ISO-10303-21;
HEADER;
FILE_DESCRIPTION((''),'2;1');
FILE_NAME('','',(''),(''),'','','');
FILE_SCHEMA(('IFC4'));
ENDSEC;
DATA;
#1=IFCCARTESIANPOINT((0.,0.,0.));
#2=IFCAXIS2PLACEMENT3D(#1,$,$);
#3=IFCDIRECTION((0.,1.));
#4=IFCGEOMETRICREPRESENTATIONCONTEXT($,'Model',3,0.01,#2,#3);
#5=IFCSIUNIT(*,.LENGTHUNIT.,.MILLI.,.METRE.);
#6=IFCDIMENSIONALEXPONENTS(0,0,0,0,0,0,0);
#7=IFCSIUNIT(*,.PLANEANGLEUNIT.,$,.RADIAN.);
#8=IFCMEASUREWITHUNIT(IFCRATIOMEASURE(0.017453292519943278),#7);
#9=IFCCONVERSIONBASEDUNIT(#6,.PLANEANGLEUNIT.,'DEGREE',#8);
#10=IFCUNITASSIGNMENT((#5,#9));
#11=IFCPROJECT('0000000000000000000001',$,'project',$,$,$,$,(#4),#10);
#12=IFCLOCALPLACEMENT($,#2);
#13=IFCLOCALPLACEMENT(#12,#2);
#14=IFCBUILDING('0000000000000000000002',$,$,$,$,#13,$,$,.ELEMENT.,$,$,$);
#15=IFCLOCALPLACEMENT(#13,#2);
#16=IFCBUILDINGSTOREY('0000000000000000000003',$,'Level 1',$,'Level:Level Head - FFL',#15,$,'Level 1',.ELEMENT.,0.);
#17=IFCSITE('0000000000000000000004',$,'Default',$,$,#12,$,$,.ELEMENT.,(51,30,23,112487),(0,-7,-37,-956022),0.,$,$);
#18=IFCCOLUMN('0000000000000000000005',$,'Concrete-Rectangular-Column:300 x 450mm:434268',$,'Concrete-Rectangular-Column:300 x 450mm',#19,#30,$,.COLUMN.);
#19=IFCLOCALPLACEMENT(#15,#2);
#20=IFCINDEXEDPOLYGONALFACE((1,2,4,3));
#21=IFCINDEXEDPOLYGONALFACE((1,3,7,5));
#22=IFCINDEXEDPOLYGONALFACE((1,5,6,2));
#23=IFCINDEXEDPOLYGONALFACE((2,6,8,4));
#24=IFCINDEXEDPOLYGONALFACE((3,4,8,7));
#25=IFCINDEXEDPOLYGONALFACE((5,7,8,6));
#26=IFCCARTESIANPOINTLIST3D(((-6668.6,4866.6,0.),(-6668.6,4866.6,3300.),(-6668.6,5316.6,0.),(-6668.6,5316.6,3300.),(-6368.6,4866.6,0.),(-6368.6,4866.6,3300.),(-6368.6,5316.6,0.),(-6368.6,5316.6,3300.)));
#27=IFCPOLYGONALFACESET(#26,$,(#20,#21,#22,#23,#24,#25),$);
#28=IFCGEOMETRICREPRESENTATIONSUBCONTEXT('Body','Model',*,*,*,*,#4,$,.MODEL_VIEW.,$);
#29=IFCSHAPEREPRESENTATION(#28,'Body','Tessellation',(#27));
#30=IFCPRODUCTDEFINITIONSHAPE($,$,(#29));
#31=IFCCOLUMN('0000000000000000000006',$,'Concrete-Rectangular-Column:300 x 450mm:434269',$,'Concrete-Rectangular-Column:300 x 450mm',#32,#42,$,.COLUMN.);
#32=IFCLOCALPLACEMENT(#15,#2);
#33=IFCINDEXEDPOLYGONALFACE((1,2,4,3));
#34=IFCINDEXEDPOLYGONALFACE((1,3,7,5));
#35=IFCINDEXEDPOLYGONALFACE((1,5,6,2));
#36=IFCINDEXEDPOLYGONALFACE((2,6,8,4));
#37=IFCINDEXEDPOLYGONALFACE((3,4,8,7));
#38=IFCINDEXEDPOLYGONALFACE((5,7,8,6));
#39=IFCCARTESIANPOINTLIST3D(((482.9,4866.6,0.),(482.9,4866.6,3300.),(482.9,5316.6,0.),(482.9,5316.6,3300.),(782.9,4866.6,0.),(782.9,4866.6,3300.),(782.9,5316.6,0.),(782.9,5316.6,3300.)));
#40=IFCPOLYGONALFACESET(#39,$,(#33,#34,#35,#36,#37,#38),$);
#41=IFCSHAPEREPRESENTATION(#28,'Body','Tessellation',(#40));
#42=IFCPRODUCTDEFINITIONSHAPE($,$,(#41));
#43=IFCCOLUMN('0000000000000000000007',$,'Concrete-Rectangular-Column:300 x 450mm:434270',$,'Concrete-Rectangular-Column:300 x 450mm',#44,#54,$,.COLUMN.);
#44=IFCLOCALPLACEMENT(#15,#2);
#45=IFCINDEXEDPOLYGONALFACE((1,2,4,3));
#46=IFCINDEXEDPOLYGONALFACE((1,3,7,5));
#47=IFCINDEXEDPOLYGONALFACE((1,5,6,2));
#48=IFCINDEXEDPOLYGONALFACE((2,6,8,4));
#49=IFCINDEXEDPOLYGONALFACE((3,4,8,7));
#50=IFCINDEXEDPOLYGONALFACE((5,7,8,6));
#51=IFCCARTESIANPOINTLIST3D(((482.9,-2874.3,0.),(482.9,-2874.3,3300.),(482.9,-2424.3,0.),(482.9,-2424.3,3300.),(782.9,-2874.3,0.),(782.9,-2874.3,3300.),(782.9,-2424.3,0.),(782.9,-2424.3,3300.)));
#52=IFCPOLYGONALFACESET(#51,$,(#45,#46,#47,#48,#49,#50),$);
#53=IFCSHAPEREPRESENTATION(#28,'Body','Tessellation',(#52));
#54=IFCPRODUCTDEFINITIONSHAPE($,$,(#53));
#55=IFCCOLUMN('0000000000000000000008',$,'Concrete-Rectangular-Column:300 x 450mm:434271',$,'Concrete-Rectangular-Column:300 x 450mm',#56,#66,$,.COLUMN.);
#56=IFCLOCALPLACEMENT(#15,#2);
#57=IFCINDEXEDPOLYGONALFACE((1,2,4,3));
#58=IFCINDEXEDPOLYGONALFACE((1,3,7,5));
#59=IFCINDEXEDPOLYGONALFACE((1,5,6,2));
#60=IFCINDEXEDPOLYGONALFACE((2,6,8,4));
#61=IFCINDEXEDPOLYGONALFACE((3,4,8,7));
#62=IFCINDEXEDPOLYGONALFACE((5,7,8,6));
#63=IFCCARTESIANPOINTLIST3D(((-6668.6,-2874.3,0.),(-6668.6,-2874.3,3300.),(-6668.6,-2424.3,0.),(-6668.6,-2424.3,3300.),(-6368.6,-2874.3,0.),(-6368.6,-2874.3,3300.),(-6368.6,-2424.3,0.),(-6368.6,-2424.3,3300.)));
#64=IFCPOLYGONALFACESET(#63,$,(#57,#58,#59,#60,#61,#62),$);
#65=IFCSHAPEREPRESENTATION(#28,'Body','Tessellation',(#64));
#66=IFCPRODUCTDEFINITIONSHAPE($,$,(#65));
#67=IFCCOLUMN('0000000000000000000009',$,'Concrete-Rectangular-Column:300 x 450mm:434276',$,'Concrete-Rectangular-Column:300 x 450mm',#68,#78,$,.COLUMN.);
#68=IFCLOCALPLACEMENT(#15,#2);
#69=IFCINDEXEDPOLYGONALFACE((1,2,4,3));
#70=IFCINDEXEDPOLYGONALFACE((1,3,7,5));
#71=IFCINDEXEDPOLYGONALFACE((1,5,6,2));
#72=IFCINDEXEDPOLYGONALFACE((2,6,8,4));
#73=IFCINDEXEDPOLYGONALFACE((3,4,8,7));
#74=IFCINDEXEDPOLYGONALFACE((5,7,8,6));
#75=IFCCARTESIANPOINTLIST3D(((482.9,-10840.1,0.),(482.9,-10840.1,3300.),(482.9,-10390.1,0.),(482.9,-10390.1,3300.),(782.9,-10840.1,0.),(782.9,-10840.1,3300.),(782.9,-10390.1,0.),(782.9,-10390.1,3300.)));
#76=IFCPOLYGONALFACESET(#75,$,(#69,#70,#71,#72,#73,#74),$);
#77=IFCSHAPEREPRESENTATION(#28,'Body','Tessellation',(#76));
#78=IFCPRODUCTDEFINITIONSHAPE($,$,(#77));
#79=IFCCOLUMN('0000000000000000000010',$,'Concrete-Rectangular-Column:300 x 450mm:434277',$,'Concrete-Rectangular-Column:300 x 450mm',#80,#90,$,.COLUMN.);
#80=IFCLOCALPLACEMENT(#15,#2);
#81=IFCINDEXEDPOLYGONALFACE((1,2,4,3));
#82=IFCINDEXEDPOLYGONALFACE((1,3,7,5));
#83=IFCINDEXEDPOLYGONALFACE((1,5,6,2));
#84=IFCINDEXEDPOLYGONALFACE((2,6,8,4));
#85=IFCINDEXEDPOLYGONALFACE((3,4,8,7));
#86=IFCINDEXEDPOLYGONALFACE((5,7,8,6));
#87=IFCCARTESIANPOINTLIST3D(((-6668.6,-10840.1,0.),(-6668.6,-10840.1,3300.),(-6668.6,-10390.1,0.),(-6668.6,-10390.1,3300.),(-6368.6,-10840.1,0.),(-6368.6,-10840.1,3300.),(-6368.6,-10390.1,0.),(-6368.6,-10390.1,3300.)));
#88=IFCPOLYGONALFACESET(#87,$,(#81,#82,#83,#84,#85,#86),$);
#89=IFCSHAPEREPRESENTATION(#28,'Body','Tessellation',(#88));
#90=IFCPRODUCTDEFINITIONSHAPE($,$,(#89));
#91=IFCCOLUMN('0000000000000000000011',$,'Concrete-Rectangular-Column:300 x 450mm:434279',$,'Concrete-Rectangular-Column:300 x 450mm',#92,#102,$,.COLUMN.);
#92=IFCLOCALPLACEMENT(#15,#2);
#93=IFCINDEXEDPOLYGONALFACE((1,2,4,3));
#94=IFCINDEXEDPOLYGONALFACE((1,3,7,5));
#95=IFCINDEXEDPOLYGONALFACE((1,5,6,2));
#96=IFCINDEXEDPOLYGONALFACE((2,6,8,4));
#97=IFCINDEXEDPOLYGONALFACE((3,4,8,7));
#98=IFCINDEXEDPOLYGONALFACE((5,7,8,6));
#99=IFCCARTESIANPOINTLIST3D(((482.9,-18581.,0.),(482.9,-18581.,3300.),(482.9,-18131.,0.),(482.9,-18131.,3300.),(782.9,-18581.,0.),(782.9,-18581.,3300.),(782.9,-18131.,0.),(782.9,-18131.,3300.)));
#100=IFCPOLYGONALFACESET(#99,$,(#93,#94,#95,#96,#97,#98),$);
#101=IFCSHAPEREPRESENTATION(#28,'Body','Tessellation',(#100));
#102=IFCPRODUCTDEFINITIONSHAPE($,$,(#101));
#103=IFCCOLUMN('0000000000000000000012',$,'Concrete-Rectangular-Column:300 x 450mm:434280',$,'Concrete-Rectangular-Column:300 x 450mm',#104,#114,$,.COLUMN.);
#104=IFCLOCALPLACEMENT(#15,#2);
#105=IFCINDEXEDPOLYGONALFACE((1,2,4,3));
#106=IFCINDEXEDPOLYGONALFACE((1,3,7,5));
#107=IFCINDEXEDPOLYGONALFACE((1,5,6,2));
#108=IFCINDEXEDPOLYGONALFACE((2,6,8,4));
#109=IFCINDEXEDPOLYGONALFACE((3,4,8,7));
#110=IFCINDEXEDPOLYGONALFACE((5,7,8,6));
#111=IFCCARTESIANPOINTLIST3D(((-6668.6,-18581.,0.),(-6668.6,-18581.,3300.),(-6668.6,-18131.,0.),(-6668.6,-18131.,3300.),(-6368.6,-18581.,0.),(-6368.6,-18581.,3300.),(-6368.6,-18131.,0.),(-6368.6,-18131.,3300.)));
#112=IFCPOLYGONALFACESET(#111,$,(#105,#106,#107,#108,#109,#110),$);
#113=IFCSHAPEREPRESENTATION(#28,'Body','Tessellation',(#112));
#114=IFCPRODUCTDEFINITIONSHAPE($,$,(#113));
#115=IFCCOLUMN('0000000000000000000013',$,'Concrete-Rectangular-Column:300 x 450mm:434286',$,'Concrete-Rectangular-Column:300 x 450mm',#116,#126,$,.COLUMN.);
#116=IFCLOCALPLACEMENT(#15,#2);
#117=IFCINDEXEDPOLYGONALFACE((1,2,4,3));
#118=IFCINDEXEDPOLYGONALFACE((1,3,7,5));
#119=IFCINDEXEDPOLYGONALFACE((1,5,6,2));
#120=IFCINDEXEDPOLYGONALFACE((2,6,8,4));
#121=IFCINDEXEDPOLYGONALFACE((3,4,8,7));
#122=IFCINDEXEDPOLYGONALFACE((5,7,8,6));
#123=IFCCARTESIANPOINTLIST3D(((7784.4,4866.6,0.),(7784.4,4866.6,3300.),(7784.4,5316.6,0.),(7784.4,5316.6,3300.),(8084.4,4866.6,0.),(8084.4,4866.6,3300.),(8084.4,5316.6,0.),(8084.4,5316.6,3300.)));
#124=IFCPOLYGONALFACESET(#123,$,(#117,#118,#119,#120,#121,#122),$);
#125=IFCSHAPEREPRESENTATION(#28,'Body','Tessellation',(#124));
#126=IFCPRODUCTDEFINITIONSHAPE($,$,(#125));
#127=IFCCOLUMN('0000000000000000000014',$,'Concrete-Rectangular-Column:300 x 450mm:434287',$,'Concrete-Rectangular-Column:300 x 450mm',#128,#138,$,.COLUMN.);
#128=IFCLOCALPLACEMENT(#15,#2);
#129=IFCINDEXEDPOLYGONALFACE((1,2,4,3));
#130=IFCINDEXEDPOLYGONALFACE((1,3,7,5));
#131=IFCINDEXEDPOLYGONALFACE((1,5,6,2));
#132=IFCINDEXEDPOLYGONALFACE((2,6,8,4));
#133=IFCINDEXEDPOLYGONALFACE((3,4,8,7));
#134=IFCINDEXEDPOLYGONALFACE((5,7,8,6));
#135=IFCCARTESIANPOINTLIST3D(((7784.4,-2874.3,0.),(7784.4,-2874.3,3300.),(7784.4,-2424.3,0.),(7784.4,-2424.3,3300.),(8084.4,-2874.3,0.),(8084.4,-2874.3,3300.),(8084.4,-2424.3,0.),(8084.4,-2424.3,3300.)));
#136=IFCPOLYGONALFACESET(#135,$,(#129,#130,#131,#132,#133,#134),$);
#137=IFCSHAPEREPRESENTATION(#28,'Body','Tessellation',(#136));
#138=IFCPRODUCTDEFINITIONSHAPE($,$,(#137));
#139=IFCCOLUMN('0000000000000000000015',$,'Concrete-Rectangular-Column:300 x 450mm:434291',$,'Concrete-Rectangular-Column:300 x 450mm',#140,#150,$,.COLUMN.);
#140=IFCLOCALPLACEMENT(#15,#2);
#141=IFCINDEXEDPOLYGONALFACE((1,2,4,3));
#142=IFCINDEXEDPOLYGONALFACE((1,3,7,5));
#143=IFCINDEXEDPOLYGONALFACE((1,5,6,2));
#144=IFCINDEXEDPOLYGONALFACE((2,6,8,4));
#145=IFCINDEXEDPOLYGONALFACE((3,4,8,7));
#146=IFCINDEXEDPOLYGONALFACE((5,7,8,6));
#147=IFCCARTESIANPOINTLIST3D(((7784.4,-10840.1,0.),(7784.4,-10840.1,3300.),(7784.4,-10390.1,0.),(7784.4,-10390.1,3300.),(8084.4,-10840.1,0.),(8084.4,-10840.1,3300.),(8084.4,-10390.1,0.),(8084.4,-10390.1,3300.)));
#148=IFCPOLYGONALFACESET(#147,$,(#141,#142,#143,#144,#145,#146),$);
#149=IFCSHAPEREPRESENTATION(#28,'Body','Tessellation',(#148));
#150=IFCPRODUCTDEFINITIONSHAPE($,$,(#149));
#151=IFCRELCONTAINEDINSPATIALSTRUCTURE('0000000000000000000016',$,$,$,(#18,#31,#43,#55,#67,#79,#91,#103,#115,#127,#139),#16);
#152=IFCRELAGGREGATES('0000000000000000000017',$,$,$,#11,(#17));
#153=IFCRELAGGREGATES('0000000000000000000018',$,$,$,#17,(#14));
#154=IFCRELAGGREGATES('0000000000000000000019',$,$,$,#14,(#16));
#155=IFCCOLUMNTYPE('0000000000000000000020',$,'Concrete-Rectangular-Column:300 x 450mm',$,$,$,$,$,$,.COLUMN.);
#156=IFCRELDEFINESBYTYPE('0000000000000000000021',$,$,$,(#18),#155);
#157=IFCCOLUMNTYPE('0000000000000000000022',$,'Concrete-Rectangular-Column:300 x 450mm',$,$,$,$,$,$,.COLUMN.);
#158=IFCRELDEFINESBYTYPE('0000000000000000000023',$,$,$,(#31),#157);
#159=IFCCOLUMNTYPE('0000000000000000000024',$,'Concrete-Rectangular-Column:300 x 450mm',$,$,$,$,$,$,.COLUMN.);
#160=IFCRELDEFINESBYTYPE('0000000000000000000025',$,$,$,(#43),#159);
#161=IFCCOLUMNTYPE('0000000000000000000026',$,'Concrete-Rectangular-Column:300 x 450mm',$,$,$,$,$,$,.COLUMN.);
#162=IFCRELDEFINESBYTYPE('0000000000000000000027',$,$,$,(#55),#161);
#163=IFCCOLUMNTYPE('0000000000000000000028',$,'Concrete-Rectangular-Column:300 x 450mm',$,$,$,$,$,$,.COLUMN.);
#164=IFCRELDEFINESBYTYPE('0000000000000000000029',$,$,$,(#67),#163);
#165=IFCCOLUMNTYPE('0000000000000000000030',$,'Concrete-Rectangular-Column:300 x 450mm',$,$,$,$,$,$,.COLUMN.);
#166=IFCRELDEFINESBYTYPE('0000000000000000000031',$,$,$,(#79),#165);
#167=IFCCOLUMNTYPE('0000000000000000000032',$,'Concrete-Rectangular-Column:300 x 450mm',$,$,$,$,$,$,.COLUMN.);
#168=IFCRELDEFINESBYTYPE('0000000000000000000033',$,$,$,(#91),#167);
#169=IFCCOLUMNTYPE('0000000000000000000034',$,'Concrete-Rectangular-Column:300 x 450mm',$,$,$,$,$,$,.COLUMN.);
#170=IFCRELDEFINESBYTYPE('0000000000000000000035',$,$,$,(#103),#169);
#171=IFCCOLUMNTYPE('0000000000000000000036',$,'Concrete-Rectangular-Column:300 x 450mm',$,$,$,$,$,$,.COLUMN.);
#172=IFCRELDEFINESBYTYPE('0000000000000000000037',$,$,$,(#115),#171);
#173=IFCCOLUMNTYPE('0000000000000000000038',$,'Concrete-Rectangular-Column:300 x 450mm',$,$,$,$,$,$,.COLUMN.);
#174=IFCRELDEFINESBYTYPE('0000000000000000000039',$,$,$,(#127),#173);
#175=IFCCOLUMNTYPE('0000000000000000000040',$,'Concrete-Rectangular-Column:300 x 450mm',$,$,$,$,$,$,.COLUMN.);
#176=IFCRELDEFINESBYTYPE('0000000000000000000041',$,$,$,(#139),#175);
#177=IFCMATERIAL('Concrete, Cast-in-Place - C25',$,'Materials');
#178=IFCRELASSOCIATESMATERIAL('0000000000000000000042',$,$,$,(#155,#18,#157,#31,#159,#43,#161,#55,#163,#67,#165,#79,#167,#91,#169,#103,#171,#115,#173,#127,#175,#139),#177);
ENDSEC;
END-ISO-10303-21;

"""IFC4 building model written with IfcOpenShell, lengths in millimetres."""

from ifc_helpers import new_model, entity, si_unit, converted_unit, direction, frame, origin, place, context, subcontext, project, spatial, indexed_curve, outline, extrude, source, transform, mapped, material, type_object, type_shapes, element, save


model = new_model("IFC4")

# Units and contexts
model_context = context("Model", 3, precision=0.01, world=origin(), true_north=direction((0.0, 1.0)))
body_context = subcontext(model_context, "Body", "Model", "MODEL_VIEW")
ifc_project = project(units=[si_unit("LENGTHUNIT", "METRE", prefix="MILLI"), converted_unit("PLANEANGLEUNIT", "DEGREE", entity("IfcRatioMeasure", 0.017453292519943278), si_unit("PLANEANGLEUNIT", "RADIAN"), dimensions=[0, 0, 0, 0, 0, 0, 0])], contexts=[model_context])

# Site, building, storey
site_placement = place(None, origin())
site = spatial("IfcSite", under=ifc_project, at=site_placement, Name="Default", CompositionType="ELEMENT", RefLatitude=(51, 30, 23, 112487), RefLongitude=(0, -7, -37, -956022), RefElevation=0.0)
building_placement = place(site_placement, origin())
building = spatial("IfcBuilding", under=site, at=building_placement, CompositionType="ELEMENT")
storey_placement = place(building_placement, origin())
storey = spatial("IfcBuildingStorey", under=building, at=storey_placement, Name="Level 1", ObjectType="Level:Level Head - FFL", LongName="Level 1", CompositionType="ELEMENT", Elevation=0.0)

# Columns
ifc_material = material(Name="Concrete, Cast-in-Place - C25", Category="Materials")
column_type_1 = type_object("IfcColumnType", Name="Concrete-Rectangular-Column:300 x 450mm", PredefinedType="COLUMN", material=ifc_material)
shared_shape_1 = source(origin(), body_context, "Body", "SweptSolid", [
    extrude(outline(indexed_curve([(-225.0, -150.0), (225.0, -150.0), (225.0, 150.0), (-225.0, 150.0), (-225.0, -150.0)], self_intersect=False)), frame((-6518.6, 5091.6, 0.0), z_axis=(0.0, 0.0, 1.0), x_axis=(0.0, -1.0, 0.0)), (0.0, 0.0, 1.0), 3300.0),
])
type_shapes(column_type_1, [shared_shape_1])
column_1_placement = place(storey_placement, origin())
element("IfcColumn", 1, at=column_1_placement, inside=storey, type_object=column_type_1, material=ifc_material, Name="Concrete-Rectangular-Column:300 x 450mm:434268", ObjectType="Concrete-Rectangular-Column:300 x 450mm", PredefinedType="COLUMN", context=body_context, shape_type="MappedRepresentation", body=[
    mapped(shared_shape_1, transform((0.0, 0.0, 0.0), scale=1.0)),
])
column_type_2 = type_object("IfcColumnType", Name="Concrete-Rectangular-Column:300 x 450mm", PredefinedType="COLUMN", material=ifc_material)
shared_shape_2 = source(origin(), body_context, "Body", "SweptSolid", [
    extrude(outline(indexed_curve([(-225.0, -150.0), (225.0, -150.0), (225.0, 150.0), (-225.0, 150.0), (-225.0, -150.0)], self_intersect=False)), frame((632.9, 5091.6, 0.0), z_axis=(0.0, 0.0, 1.0), x_axis=(0.0, -1.0, 0.0)), (0.0, 0.0, 1.0), 3300.0),
])
type_shapes(column_type_2, [shared_shape_2])
column_2_placement = place(storey_placement, origin())
element("IfcColumn", 2, at=column_2_placement, inside=storey, type_object=column_type_2, material=ifc_material, Name="Concrete-Rectangular-Column:300 x 450mm:434269", ObjectType="Concrete-Rectangular-Column:300 x 450mm", PredefinedType="COLUMN", context=body_context, shape_type="MappedRepresentation", body=[
    mapped(shared_shape_2, transform((0.0, 0.0, 0.0), scale=1.0)),
])
column_type_3 = type_object("IfcColumnType", Name="Concrete-Rectangular-Column:300 x 450mm", PredefinedType="COLUMN", material=ifc_material)
shared_shape_3 = source(origin(), body_context, "Body", "SweptSolid", [
    extrude(outline(indexed_curve([(-225.0, -150.0), (225.0, -150.0), (225.0, 150.0), (-225.0, 150.0), (-225.0, -150.0)], self_intersect=False)), frame((632.9, -2649.3, 0.0), z_axis=(0.0, 0.0, 1.0), x_axis=(0.0, -1.0, 0.0)), (0.0, 0.0, 1.0), 3300.0),
])
type_shapes(column_type_3, [shared_shape_3])
column_3_placement = place(storey_placement, origin())
element("IfcColumn", 3, at=column_3_placement, inside=storey, type_object=column_type_3, material=ifc_material, Name="Concrete-Rectangular-Column:300 x 450mm:434270", ObjectType="Concrete-Rectangular-Column:300 x 450mm", PredefinedType="COLUMN", context=body_context, shape_type="MappedRepresentation", body=[
    mapped(shared_shape_3, transform((0.0, 0.0, 0.0), scale=1.0)),
])
column_type_4 = type_object("IfcColumnType", Name="Concrete-Rectangular-Column:300 x 450mm", PredefinedType="COLUMN", material=ifc_material)
shared_shape_4 = source(origin(), body_context, "Body", "SweptSolid", [
    extrude(outline(indexed_curve([(-225.0, -150.0), (225.0, -150.0), (225.0, 150.0), (-225.0, 150.0), (-225.0, -150.0)], self_intersect=False)), frame((-6518.6, -2649.3, 0.0), z_axis=(0.0, 0.0, 1.0), x_axis=(0.0, -1.0, 0.0)), (0.0, 0.0, 1.0), 3300.0),
])
type_shapes(column_type_4, [shared_shape_4])
column_4_placement = place(storey_placement, origin())
element("IfcColumn", 4, at=column_4_placement, inside=storey, type_object=column_type_4, material=ifc_material, Name="Concrete-Rectangular-Column:300 x 450mm:434271", ObjectType="Concrete-Rectangular-Column:300 x 450mm", PredefinedType="COLUMN", context=body_context, shape_type="MappedRepresentation", body=[
    mapped(shared_shape_4, transform((0.0, 0.0, 0.0), scale=1.0)),
])
column_type_5 = type_object("IfcColumnType", Name="Concrete-Rectangular-Column:300 x 450mm", PredefinedType="COLUMN", material=ifc_material)
shared_shape_5 = source(origin(), body_context, "Body", "SweptSolid", [
    extrude(outline(indexed_curve([(-225.0, -150.0), (225.0, -150.0), (225.0, 150.0), (-225.0, 150.0), (-225.0, -150.0)], self_intersect=False)), frame((632.9, -10615.1, 0.0), z_axis=(0.0, 0.0, 1.0), x_axis=(0.0, -1.0, 0.0)), (0.0, 0.0, 1.0), 3300.0),
])
type_shapes(column_type_5, [shared_shape_5])
column_5_placement = place(storey_placement, origin())
element("IfcColumn", 5, at=column_5_placement, inside=storey, type_object=column_type_5, material=ifc_material, Name="Concrete-Rectangular-Column:300 x 450mm:434276", ObjectType="Concrete-Rectangular-Column:300 x 450mm", PredefinedType="COLUMN", context=body_context, shape_type="MappedRepresentation", body=[
    mapped(shared_shape_5, transform((0.0, 0.0, 0.0), scale=1.0)),
])
column_type_6 = type_object("IfcColumnType", Name="Concrete-Rectangular-Column:300 x 450mm", PredefinedType="COLUMN", material=ifc_material)
shared_shape_6 = source(origin(), body_context, "Body", "SweptSolid", [
    extrude(outline(indexed_curve([(-225.0, -150.0), (225.0, -150.0), (225.0, 150.0), (-225.0, 150.0), (-225.0, -150.0)], self_intersect=False)), frame((-6518.6, -10615.1, 0.0), z_axis=(0.0, 0.0, 1.0), x_axis=(0.0, -1.0, 0.0)), (0.0, 0.0, 1.0), 3300.0),
])
type_shapes(column_type_6, [shared_shape_6])
column_6_placement = place(storey_placement, origin())
element("IfcColumn", 6, at=column_6_placement, inside=storey, type_object=column_type_6, material=ifc_material, Name="Concrete-Rectangular-Column:300 x 450mm:434277", ObjectType="Concrete-Rectangular-Column:300 x 450mm", PredefinedType="COLUMN", context=body_context, shape_type="MappedRepresentation", body=[
    mapped(shared_shape_6, transform((0.0, 0.0, 0.0), scale=1.0)),
])
column_type_7 = type_object("IfcColumnType", Name="Concrete-Rectangular-Column:300 x 450mm", PredefinedType="COLUMN", material=ifc_material)
shared_shape_7 = source(origin(), body_context, "Body", "SweptSolid", [
    extrude(outline(indexed_curve([(-225.0, -150.0), (225.0, -150.0), (225.0, 150.0), (-225.0, 150.0), (-225.0, -150.0)], self_intersect=False)), frame((632.9, -18356.0, 0.0), z_axis=(0.0, 0.0, 1.0), x_axis=(0.0, -1.0, 0.0)), (0.0, 0.0, 1.0), 3300.0),
])
type_shapes(column_type_7, [shared_shape_7])
column_7_placement = place(storey_placement, origin())
element("IfcColumn", 7, at=column_7_placement, inside=storey, type_object=column_type_7, material=ifc_material, Name="Concrete-Rectangular-Column:300 x 450mm:434279", ObjectType="Concrete-Rectangular-Column:300 x 450mm", PredefinedType="COLUMN", context=body_context, shape_type="MappedRepresentation", body=[
    mapped(shared_shape_7, transform((0.0, 0.0, 0.0), scale=1.0)),
])
column_type_8 = type_object("IfcColumnType", Name="Concrete-Rectangular-Column:300 x 450mm", PredefinedType="COLUMN", material=ifc_material)
shared_shape_8 = source(origin(), body_context, "Body", "SweptSolid", [
    extrude(outline(indexed_curve([(-225.0, -150.0), (225.0, -150.0), (225.0, 150.0), (-225.0, 150.0), (-225.0, -150.0)], self_intersect=False)), frame((-6518.6, -18356.0, 0.0), z_axis=(0.0, 0.0, 1.0), x_axis=(0.0, -1.0, 0.0)), (0.0, 0.0, 1.0), 3300.0),
])
type_shapes(column_type_8, [shared_shape_8])
column_8_placement = place(storey_placement, origin())
element("IfcColumn", 8, at=column_8_placement, inside=storey, type_object=column_type_8, material=ifc_material, Name="Concrete-Rectangular-Column:300 x 450mm:434280", ObjectType="Concrete-Rectangular-Column:300 x 450mm", PredefinedType="COLUMN", context=body_context, shape_type="MappedRepresentation", body=[
    mapped(shared_shape_8, transform((0.0, 0.0, 0.0), scale=1.0)),
])
column_type_9 = type_object("IfcColumnType", Name="Concrete-Rectangular-Column:300 x 450mm", PredefinedType="COLUMN", material=ifc_material)
shared_shape_9 = source(origin(), body_context, "Body", "SweptSolid", [
    extrude(outline(indexed_curve([(-225.0, -150.0), (225.0, -150.0), (225.0, 150.0), (-225.0, 150.0), (-225.0, -150.0)], self_intersect=False)), frame((7934.4, 5091.6, 0.0), z_axis=(0.0, 0.0, 1.0), x_axis=(0.0, -1.0, 0.0)), (0.0, 0.0, 1.0), 3300.0),
])
type_shapes(column_type_9, [shared_shape_9])
column_9_placement = place(storey_placement, origin())
element("IfcColumn", 9, at=column_9_placement, inside=storey, type_object=column_type_9, material=ifc_material, Name="Concrete-Rectangular-Column:300 x 450mm:434286", ObjectType="Concrete-Rectangular-Column:300 x 450mm", PredefinedType="COLUMN", context=body_context, shape_type="MappedRepresentation", body=[
    mapped(shared_shape_9, transform((0.0, 0.0, 0.0), scale=1.0)),
])
column_type_10 = type_object("IfcColumnType", Name="Concrete-Rectangular-Column:300 x 450mm", PredefinedType="COLUMN", material=ifc_material)
shared_shape_10 = source(origin(), body_context, "Body", "SweptSolid", [
    extrude(outline(indexed_curve([(-225.0, -150.0), (225.0, -150.0), (225.0, 150.0), (-225.0, 150.0), (-225.0, -150.0)], self_intersect=False)), frame((7934.4, -2649.3, 0.0), z_axis=(0.0, 0.0, 1.0), x_axis=(0.0, -1.0, 0.0)), (0.0, 0.0, 1.0), 3300.0),
])
type_shapes(column_type_10, [shared_shape_10])
column_10_placement = place(storey_placement, origin())
element("IfcColumn", 10, at=column_10_placement, inside=storey, type_object=column_type_10, material=ifc_material, Name="Concrete-Rectangular-Column:300 x 450mm:434287", ObjectType="Concrete-Rectangular-Column:300 x 450mm", PredefinedType="COLUMN", context=body_context, shape_type="MappedRepresentation", body=[
    mapped(shared_shape_10, transform((0.0, 0.0, 0.0), scale=1.0)),
])
column_type_11 = type_object("IfcColumnType", Name="Concrete-Rectangular-Column:300 x 450mm", PredefinedType="COLUMN", material=ifc_material)
shared_shape_11 = source(origin(), body_context, "Body", "SweptSolid", [
    extrude(outline(indexed_curve([(-225.0, -150.0), (225.0, -150.0), (225.0, 150.0), (-225.0, 150.0), (-225.0, -150.0)], self_intersect=False)), frame((7934.4, -10615.1, 0.0), z_axis=(0.0, 0.0, 1.0), x_axis=(0.0, -1.0, 0.0)), (0.0, 0.0, 1.0), 3300.0),
])
type_shapes(column_type_11, [shared_shape_11])
column_11_placement = place(storey_placement, origin())
element("IfcColumn", 11, at=column_11_placement, inside=storey, type_object=column_type_11, material=ifc_material, Name="Concrete-Rectangular-Column:300 x 450mm:434291", ObjectType="Concrete-Rectangular-Column:300 x 450mm", PredefinedType="COLUMN", context=body_context, shape_type="MappedRepresentation", body=[
    mapped(shared_shape_11, transform((0.0, 0.0, 0.0), scale=1.0)),
])

save(model, "model.ifc")
